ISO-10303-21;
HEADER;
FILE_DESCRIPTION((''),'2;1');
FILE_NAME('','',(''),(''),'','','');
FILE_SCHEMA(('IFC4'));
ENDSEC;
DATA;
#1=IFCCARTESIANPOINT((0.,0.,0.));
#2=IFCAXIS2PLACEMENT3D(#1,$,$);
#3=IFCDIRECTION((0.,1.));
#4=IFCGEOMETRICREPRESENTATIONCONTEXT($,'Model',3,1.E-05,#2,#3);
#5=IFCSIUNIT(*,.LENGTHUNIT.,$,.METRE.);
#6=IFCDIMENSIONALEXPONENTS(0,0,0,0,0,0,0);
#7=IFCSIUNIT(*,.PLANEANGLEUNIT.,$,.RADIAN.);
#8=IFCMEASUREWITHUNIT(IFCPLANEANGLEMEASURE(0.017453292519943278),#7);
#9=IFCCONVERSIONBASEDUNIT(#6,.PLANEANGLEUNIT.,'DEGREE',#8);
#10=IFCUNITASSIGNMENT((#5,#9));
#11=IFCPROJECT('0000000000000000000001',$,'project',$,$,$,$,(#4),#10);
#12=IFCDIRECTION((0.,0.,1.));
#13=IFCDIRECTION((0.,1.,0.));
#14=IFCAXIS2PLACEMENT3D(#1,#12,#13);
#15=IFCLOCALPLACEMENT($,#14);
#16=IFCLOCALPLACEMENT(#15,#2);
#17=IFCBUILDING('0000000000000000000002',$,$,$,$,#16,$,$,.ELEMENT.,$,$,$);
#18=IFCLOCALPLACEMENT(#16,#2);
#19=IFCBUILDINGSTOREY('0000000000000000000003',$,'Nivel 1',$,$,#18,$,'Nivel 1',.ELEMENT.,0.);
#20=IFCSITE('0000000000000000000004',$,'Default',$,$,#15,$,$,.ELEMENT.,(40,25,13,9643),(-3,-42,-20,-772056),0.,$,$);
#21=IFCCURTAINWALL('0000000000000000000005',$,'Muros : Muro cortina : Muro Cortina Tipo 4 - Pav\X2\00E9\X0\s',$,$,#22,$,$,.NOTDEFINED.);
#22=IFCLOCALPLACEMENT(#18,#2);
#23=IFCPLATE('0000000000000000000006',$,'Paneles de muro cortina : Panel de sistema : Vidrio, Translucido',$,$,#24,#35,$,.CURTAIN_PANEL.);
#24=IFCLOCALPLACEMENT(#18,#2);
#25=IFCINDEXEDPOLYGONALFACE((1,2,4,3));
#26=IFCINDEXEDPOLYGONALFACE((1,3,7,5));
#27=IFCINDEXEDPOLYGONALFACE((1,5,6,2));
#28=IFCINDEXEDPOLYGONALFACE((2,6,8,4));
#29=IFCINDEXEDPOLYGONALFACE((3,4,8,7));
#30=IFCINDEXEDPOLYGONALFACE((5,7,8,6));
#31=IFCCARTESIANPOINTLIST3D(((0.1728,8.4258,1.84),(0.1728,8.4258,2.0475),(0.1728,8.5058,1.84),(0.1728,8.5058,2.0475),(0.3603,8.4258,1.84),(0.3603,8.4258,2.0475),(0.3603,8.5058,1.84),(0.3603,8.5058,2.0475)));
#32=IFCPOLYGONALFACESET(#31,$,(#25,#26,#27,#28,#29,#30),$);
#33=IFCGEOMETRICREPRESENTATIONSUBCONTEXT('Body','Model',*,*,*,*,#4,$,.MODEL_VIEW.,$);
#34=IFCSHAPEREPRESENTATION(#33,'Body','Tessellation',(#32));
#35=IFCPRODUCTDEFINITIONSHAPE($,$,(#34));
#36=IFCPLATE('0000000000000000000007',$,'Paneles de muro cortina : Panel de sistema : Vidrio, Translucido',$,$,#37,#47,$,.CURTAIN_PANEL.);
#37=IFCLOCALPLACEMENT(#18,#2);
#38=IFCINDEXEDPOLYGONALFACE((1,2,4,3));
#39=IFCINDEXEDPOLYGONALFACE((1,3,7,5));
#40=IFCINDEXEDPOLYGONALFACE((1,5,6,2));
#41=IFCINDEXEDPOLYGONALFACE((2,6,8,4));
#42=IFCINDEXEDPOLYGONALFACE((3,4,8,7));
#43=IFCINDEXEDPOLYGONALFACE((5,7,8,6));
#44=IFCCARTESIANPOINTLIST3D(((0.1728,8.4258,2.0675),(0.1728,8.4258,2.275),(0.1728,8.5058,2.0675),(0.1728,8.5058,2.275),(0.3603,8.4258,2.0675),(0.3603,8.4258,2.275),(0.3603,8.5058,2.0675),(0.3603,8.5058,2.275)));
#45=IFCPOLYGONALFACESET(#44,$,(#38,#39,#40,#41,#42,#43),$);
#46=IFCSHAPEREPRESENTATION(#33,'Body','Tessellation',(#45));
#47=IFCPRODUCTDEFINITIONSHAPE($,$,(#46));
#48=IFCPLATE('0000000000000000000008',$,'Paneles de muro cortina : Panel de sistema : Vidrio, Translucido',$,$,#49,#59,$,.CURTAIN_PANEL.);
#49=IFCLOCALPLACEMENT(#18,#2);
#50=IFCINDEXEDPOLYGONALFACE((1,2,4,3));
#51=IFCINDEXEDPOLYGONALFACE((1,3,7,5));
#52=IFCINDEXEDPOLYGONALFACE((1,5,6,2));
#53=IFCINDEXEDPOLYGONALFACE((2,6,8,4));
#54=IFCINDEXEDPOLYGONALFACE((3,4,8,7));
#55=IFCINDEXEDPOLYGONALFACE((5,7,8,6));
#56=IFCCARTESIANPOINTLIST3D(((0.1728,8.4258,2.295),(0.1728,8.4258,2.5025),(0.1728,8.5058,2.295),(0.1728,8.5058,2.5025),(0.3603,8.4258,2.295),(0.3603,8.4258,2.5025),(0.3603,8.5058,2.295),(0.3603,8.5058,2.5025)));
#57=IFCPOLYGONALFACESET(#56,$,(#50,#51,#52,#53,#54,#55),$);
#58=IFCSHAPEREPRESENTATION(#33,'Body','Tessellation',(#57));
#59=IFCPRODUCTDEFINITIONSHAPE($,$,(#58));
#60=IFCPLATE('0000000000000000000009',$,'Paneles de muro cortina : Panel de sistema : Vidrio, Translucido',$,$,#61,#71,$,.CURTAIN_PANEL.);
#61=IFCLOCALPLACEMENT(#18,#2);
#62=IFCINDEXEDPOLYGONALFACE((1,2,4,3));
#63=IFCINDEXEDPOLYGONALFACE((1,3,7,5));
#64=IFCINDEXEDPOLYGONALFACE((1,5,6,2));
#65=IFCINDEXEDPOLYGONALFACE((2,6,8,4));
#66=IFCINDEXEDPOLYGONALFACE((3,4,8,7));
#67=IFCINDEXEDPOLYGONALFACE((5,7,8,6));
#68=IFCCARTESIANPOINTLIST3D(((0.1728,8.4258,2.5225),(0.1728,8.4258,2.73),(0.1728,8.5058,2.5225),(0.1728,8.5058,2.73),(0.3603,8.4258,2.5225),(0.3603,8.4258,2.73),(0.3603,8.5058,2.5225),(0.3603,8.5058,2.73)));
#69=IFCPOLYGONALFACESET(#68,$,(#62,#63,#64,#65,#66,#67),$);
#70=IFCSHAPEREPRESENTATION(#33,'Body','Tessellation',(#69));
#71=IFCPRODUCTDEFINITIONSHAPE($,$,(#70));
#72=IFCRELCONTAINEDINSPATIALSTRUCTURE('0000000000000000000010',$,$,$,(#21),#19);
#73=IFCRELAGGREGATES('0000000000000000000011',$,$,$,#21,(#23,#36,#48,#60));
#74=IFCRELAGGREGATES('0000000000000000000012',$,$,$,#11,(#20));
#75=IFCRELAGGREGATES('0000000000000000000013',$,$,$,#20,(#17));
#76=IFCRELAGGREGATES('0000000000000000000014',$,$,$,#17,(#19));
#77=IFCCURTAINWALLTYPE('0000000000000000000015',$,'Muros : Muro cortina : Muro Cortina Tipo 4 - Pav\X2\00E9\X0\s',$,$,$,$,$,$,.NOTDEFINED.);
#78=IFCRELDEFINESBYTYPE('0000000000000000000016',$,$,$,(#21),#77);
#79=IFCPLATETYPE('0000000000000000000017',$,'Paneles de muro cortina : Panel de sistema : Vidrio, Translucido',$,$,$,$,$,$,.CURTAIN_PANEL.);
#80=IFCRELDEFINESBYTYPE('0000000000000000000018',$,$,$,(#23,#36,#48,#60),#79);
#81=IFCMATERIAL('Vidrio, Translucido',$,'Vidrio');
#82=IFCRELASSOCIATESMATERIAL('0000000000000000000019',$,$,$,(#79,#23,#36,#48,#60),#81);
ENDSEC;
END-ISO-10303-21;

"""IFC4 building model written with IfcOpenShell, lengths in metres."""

from ifc_helpers import new_model, entity, si_unit, converted_unit, direction, frame, origin, place, context, subcontext, project, spatial, indexed_curve, outline, extrude, source, transform, mapped, material, type_object, type_shapes, element, aggregate, save


model = new_model("IFC4")

# Units and contexts
model_context = context("Model", 3, precision=1e-05, world=origin(), true_north=direction((0.0, 1.0)))
body_context = subcontext(model_context, "Body", "Model", "MODEL_VIEW")
ifc_project = project(units=[si_unit("LENGTHUNIT", "METRE"), converted_unit("PLANEANGLEUNIT", "DEGREE", entity("IfcPlaneAngleMeasure", 0.017453292519943278), si_unit("PLANEANGLEUNIT", "RADIAN"), dimensions=[0, 0, 0, 0, 0, 0, 0])], contexts=[model_context])

# Site, building, storey
site_placement = place(None, frame((0.0, 0.0, 0.0), z_axis=(0.0, 0.0, 1.0), x_axis=(0.0, 1.0, 0.0)))
site = spatial("IfcSite", under=ifc_project, at=site_placement, Name="Default", CompositionType="ELEMENT", RefLatitude=(40, 25, 13, 9643), RefLongitude=(-3, -42, -20, -772056), RefElevation=0.0)
building_placement = place(site_placement, origin())
building = spatial("IfcBuilding", under=site, at=building_placement, CompositionType="ELEMENT")
storey_placement = place(building_placement, origin())
storey = spatial("IfcBuildingStorey", under=building, at=storey_placement, Name="Nivel 1", LongName="Nivel 1", CompositionType="ELEMENT", Elevation=0.0)

# Curtain wall, plates
curtain_wall_type = type_object("IfcCurtainWallType", Name="Muros : Muro cortina : Muro Cortina Tipo 4 - Pavés", PredefinedType="NOTDEFINED")
curtain_wall_placement = place(storey_placement, origin())
curtain_wall = element("IfcCurtainWall", 1, at=curtain_wall_placement, inside=storey, type_object=curtain_wall_type, Name="Muros : Muro cortina : Muro Cortina Tipo 4 - Pavés", PredefinedType="NOTDEFINED")
ifc_material_1 = material(Name="Vidrio, Translucido", Category="Vidrio")
plate_type = type_object("IfcPlateType", Name="Paneles de muro cortina : Panel de sistema : Vidrio, Translucido", PredefinedType="CURTAIN_PANEL", material=ifc_material_1)
shared_shape_1 = source(origin(), body_context, "Body", "SweptSolid", [
    extrude(outline(indexed_curve([(-0.04, -0.0938), (0.04, -0.0938), (0.04, 0.0938), (-0.04, 0.0938), (-0.04, -0.0938)], self_intersect=False)), frame((0.0, 0.0, 0.0), z_axis=(0.0, 0.0, 1.0), x_axis=(0.0, 1.0, 0.0)), (0.0, 0.0, 1.0), 0.2075),
])
type_shapes(plate_type, [shared_shape_1])
plate_1_placement = place(curtain_wall_placement, frame((0.2665, 8.4658, 1.84), z_axis=(0.0, 0.0, 1.0), x_axis=(-1.0, 0.0, 0.0)))
plate_1 = element("IfcPlate", 2, at=plate_1_placement, type_object=plate_type, material=ifc_material_1, Name="Paneles de muro cortina : Panel de sistema : Vidrio, Translucido", PredefinedType="CURTAIN_PANEL", context=body_context, shape_type="MappedRepresentation", body=[
    mapped(shared_shape_1, transform((0.0, 0.0, 0.0), scale=1.0)),
])
plate_2_placement = place(curtain_wall_placement, frame((0.2665, 8.4658, 2.0675), z_axis=(0.0, 0.0, 1.0), x_axis=(-1.0, 0.0, 0.0)))
plate_2 = element("IfcPlate", 3, at=plate_2_placement, type_object=plate_type, material=ifc_material_1, Name="Paneles de muro cortina : Panel de sistema : Vidrio, Translucido", PredefinedType="CURTAIN_PANEL", context=body_context, shape_type="MappedRepresentation", body=[
    mapped(shared_shape_1, transform((0.0, 0.0, 0.0), scale=1.0)),
])
plate_3_placement = place(curtain_wall_placement, frame((0.2665, 8.4658, 2.295), z_axis=(0.0, 0.0, 1.0), x_axis=(-1.0, 0.0, 0.0)))
plate_3 = element("IfcPlate", 4, at=plate_3_placement, type_object=plate_type, material=ifc_material_1, Name="Paneles de muro cortina : Panel de sistema : Vidrio, Translucido", PredefinedType="CURTAIN_PANEL", context=body_context, shape_type="MappedRepresentation", body=[
    mapped(shared_shape_1, transform((0.0, 0.0, 0.0), scale=1.0)),
])
plate_4_placement = place(curtain_wall_placement, frame((0.2665, 8.4658, 2.5225), z_axis=(0.0, 0.0, 1.0), x_axis=(-1.0, 0.0, 0.0)))
plate_4 = element("IfcPlate", 5, at=plate_4_placement, type_object=plate_type, material=ifc_material_1, Name="Paneles de muro cortina : Panel de sistema : Vidrio, Translucido", PredefinedType="CURTAIN_PANEL", context=body_context, shape_type="MappedRepresentation", body=[
    mapped(shared_shape_1, transform((0.0, 0.0, 0.0), scale=1.0)),
])
aggregate(curtain_wall, [plate_1, plate_2, plate_3, plate_4])

save(model, "model.ifc")
